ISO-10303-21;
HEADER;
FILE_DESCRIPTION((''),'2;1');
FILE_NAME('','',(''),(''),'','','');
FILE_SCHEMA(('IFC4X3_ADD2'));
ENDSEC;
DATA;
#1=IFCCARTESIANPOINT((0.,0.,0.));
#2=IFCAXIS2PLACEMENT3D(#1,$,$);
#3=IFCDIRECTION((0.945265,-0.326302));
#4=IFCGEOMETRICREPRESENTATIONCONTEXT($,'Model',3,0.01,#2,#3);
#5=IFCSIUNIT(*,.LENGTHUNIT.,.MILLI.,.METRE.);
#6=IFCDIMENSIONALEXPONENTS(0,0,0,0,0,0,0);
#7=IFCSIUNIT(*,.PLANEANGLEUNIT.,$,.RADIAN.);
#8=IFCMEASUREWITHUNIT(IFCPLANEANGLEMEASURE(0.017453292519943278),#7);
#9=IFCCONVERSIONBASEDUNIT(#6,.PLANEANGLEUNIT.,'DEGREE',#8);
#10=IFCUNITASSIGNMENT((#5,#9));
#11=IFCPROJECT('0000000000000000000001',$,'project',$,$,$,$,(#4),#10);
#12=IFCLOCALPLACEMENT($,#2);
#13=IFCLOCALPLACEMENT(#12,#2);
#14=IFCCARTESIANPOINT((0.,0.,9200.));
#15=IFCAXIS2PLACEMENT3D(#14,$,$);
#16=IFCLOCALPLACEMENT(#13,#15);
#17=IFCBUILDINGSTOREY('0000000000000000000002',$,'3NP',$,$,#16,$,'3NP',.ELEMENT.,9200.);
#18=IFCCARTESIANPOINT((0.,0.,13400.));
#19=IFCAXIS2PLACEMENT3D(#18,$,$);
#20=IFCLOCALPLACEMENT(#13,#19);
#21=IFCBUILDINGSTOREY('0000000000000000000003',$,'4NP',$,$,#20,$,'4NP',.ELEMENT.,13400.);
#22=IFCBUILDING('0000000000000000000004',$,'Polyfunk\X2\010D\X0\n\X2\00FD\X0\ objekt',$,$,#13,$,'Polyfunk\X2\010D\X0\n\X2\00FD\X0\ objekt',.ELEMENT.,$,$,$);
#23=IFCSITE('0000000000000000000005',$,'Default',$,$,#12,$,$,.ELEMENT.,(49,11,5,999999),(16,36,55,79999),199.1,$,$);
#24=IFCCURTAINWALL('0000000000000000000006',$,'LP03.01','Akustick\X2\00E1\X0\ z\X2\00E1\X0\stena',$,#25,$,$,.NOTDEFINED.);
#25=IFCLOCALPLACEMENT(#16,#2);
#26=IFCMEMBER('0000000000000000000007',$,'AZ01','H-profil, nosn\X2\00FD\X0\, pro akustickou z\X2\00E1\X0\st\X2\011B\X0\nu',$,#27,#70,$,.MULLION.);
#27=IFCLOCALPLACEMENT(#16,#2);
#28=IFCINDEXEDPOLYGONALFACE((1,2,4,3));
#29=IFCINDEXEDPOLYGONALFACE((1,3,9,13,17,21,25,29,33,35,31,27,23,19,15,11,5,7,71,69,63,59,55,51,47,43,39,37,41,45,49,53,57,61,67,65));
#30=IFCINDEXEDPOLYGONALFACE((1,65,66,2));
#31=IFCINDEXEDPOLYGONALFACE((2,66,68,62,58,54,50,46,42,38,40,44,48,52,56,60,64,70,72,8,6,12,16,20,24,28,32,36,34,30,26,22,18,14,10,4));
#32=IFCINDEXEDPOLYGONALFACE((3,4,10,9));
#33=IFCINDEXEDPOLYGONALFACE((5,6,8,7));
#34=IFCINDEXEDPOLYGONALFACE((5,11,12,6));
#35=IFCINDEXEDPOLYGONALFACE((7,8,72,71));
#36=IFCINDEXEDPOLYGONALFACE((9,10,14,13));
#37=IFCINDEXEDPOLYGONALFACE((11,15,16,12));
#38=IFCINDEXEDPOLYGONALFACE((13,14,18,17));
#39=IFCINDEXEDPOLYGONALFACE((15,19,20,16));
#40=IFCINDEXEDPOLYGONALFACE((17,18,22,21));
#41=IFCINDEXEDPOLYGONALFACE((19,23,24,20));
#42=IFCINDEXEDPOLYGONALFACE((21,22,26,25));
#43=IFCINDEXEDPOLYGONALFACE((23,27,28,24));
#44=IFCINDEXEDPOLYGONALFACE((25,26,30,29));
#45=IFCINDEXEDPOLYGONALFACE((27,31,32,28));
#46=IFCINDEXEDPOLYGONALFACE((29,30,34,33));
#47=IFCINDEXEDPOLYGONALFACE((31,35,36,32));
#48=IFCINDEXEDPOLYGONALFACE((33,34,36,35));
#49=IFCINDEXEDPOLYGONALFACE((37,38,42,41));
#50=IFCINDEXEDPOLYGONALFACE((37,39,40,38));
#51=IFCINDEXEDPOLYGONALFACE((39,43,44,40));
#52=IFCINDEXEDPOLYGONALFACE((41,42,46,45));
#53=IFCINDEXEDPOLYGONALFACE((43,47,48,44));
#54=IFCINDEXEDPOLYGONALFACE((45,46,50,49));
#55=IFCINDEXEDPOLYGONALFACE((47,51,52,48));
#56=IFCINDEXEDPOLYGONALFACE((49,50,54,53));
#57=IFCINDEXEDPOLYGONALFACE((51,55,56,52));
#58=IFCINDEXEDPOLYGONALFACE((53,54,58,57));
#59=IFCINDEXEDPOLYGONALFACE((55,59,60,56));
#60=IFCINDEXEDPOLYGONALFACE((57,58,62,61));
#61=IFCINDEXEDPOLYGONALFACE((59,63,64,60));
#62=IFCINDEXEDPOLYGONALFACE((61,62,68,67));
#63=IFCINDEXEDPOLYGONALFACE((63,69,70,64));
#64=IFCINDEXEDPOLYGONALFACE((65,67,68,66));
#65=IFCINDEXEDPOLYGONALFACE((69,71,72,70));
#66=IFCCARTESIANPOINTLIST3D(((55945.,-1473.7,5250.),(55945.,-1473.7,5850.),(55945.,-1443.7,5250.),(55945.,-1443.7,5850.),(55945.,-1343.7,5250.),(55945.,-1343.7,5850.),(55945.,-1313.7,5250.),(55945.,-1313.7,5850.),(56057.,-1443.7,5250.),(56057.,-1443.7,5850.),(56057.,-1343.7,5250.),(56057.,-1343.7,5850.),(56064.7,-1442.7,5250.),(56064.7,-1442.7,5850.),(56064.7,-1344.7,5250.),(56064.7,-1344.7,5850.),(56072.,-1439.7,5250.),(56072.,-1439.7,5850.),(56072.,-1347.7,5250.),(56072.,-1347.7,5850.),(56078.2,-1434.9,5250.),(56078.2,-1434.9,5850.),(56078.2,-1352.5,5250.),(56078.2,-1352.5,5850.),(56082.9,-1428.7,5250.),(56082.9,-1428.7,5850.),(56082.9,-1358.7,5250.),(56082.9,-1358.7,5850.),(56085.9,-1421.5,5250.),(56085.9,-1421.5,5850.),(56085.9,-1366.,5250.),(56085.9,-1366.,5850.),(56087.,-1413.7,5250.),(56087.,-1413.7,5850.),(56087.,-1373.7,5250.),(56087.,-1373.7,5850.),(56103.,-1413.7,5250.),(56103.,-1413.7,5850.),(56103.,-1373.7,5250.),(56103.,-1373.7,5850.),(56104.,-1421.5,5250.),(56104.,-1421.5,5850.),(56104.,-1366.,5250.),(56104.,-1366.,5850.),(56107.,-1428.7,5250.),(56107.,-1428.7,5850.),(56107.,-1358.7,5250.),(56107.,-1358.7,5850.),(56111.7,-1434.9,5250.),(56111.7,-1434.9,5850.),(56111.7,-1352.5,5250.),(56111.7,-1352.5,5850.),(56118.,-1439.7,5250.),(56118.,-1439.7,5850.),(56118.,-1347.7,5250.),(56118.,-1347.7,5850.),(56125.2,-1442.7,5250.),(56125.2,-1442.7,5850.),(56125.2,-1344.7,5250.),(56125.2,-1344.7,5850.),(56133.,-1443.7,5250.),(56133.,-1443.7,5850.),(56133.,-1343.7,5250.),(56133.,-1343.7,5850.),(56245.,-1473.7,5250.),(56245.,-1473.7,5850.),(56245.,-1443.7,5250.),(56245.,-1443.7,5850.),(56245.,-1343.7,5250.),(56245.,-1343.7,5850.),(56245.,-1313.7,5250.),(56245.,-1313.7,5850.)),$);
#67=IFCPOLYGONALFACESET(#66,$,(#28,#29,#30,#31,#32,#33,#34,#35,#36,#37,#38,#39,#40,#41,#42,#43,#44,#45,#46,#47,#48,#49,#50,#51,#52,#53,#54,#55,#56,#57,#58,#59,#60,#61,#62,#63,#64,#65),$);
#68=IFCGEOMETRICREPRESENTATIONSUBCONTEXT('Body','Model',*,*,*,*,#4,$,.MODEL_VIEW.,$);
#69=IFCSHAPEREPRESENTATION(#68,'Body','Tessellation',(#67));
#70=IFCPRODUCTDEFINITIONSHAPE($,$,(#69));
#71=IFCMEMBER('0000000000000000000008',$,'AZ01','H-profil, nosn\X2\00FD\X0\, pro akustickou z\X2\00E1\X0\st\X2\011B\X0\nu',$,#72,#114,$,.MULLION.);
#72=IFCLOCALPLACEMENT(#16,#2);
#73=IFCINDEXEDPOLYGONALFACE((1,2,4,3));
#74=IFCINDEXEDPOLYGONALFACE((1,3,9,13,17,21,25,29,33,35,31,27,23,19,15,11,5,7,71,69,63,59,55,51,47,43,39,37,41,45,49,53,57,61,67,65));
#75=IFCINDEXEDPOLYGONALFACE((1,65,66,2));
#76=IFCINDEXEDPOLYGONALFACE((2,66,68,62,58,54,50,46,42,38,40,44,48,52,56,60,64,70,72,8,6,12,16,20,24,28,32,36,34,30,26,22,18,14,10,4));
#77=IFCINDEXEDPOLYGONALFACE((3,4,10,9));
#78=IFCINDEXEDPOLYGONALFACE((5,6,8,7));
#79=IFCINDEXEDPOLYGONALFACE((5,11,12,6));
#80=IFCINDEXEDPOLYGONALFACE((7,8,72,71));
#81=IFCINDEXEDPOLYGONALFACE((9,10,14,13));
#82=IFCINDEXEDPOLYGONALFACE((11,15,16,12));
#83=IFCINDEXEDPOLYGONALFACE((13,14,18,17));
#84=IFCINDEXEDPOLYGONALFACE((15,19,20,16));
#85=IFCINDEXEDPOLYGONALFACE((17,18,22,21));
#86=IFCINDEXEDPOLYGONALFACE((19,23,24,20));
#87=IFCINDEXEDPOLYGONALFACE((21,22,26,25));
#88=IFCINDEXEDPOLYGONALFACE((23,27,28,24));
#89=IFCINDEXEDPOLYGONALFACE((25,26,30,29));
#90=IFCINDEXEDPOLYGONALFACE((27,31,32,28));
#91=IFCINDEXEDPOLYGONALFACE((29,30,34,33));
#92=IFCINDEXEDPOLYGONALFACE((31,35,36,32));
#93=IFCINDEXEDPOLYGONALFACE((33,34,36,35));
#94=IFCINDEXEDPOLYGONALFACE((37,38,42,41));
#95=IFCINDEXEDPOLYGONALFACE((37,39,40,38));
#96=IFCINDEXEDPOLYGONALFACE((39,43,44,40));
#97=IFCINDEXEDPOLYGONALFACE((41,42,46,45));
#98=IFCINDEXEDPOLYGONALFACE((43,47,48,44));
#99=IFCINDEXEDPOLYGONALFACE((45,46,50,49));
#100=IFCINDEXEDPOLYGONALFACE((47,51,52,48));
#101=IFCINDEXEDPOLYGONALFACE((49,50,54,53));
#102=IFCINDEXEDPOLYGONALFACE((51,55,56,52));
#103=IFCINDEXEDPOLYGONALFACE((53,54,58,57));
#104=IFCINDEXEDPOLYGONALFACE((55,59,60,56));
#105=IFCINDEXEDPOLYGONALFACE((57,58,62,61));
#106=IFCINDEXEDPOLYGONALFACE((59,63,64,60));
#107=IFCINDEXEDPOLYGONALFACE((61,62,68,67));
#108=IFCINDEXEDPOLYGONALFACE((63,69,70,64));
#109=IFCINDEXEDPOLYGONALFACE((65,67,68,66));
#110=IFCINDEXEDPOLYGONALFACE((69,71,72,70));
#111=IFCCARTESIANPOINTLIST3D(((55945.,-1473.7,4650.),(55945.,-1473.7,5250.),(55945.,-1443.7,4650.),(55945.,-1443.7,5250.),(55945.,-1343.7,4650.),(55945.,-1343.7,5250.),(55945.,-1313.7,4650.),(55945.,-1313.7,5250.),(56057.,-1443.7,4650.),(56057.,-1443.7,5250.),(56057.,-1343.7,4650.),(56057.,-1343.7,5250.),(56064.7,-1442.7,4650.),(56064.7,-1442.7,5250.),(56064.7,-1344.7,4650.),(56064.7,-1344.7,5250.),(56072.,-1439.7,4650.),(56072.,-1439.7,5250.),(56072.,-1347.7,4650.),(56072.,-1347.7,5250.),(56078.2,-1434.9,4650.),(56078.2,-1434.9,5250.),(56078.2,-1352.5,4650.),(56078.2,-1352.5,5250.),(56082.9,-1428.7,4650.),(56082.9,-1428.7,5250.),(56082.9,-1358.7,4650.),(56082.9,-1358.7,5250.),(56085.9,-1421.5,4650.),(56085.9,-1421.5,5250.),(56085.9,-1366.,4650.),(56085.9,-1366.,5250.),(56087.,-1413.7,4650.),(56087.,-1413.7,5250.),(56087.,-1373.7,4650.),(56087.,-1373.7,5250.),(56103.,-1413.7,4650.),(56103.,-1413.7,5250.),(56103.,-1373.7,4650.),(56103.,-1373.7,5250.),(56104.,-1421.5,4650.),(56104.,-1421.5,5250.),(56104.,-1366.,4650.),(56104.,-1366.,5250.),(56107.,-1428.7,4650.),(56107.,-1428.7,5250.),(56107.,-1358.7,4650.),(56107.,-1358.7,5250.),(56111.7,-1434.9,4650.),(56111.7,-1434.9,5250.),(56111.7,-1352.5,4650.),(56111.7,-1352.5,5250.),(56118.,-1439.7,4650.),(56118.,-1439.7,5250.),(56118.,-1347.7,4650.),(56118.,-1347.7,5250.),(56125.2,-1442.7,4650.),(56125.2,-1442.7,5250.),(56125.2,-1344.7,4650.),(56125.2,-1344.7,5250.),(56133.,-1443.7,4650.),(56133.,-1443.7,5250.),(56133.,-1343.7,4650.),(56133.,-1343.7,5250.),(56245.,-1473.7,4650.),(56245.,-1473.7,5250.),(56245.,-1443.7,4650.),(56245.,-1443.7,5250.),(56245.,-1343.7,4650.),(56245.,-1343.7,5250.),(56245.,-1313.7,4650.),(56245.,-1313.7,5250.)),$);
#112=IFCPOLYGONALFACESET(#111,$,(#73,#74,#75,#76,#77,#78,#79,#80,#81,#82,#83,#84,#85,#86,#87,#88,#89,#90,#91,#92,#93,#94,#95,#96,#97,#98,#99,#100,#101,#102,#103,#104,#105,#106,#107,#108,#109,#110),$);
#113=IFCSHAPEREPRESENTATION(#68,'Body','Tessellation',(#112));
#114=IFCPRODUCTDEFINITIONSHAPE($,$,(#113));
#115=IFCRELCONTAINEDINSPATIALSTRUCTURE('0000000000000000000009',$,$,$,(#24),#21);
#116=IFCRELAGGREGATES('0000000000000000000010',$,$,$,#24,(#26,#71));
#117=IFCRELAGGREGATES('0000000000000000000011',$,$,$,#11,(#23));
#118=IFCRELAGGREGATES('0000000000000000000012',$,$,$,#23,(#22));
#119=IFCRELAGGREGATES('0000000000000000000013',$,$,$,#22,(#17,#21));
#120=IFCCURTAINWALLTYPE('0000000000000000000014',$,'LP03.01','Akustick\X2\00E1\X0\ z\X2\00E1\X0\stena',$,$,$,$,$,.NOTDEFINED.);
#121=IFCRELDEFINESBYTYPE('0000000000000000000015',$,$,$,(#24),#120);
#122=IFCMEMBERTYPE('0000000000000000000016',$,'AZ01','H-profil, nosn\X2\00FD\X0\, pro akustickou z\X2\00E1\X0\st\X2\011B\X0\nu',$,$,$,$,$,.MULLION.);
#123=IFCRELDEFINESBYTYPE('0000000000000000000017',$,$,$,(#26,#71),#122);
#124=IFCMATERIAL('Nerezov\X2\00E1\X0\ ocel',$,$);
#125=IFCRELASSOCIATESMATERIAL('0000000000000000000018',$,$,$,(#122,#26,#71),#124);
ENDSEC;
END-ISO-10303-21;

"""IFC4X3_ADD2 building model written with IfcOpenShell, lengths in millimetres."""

from ifc_helpers import new_model, entity, si_unit, converted_unit, direction, frame, frame_2d, origin, place, context, subcontext, project, spatial, polyline, circle_curve, parameter, trimmed, segment, composite_curve, outline, extrude, source, transform, mapped, material, material_profile, profile_set, profile_usage, type_object, element, aggregate, save


model = new_model("IFC4X3_ADD2")

# Units and contexts
model_context = context("Model", 3, precision=0.01, world=origin(), true_north=direction((0.945265, -0.326302)))
body_context = subcontext(model_context, "Body", "Model", "MODEL_VIEW")
ifc_project = project(units=[si_unit("LENGTHUNIT", "METRE", prefix="MILLI"), converted_unit("PLANEANGLEUNIT", "DEGREE", entity("IfcPlaneAngleMeasure", 0.017453292519943278), si_unit("PLANEANGLEUNIT", "RADIAN"), dimensions=[0, 0, 0, 0, 0, 0, 0])], contexts=[model_context])

# Site, building, storey
site_placement = place(None, origin())
site = spatial("IfcSite", under=ifc_project, at=site_placement, Name="Default", CompositionType="ELEMENT", RefLatitude=(49, 11, 5, 999999), RefLongitude=(16, 36, 55, 79999), RefElevation=199.1)
building_placement = place(site_placement, origin())
building = spatial("IfcBuilding", under=site, at=building_placement, Name="Polyfunkčný objekt", LongName="Polyfunkčný objekt", CompositionType="ELEMENT")
storey_1_placement = place(building_placement, frame((0.0, 0.0, 9200.0)))
storey_1 = spatial("IfcBuildingStorey", under=building, at=storey_1_placement, Name="3NP", LongName="3NP", CompositionType="ELEMENT", Elevation=9200.0)

# Shared definitions
storey_2_placement = place(building_placement, frame((0.0, 0.0, 13400.0)))
storey_2 = spatial("IfcBuildingStorey", under=building, at=storey_2_placement, Name="4NP", LongName="4NP", CompositionType="ELEMENT", Elevation=13400.0)

# Curtain wall, members
curtain_wall_type_1 = type_object("IfcCurtainWallType", Name="LP03.01", Description="Akustická zástena", PredefinedType="NOTDEFINED")
ifc_material_1 = material(Name="Nerezová ocel")
ifc_material_profile_1 = material_profile(ifc_material_1, outline(composite_curve([segment(polyline([(50.0, -150.0), (80.0, -150.0)]), True, "CONTINUOUS"), segment(polyline([(80.0, -150.0), (80.0, 150.0)]), True, "CONTINUOUS"), segment(polyline([(80.0, 150.0), (50.0, 150.0)]), True, "CONTINUOUS"), segment(polyline([(50.0, 150.0), (50.0, 38.0)]), True, "CONTINUOUS"), segment(trimmed(circle_curve(frame_2d((20.0, 38.0), x_axis=(0.0, 1.0)), 30.0), [parameter(180.0)], [parameter(270.0)], True, "PARAMETER"), False, "CONTINUOUS"), segment(polyline([(20.0, 8.0), (-20.0, 8.0)]), True, "CONTINUOUS"), segment(trimmed(circle_curve(frame_2d((-20.0, 38.0), x_axis=(0.0, 1.0)), 30.0), [parameter(90.0)], [parameter(180.0)], True, "PARAMETER"), False, "CONTINUOUS"), segment(polyline([(-50.0, 38.0), (-50.0, 150.0)]), True, "CONTINUOUS"), segment(polyline([(-50.0, 150.0), (-80.0, 150.0)]), True, "CONTINUOUS"), segment(polyline([(-80.0, 150.0), (-80.0, -150.0)]), True, "CONTINUOUS"), segment(polyline([(-80.0, -150.0), (-50.0, -150.0)]), True, "CONTINUOUS"), segment(polyline([(-50.0, -150.0), (-50.0, -38.0)]), True, "CONTINUOUS"), segment(trimmed(circle_curve(frame_2d((-20.0, -38.0), x_axis=(0.0, 1.0)), 30.0), [parameter(0.0)], [parameter(90.0)], True, "PARAMETER"), False, "CONTINUOUS"), segment(polyline([(-20.0, -8.0), (20.0, -8.0)]), True, "CONTINUOUS"), segment(trimmed(circle_curve(frame_2d((20.0, -38.0), x_axis=(0.0, 1.0)), 30.0), [parameter(270.0)], [parameter(0.0)], True, "PARAMETER"), False, "CONTINUOUS"), segment(polyline([(50.0, -38.0), (50.0, -150.0)]), True, "CONTINUOUS")], self_intersect=False)), Name="Profil zástena")
ifc_profile_set_1 = profile_set([ifc_material_profile_1], Name="Profil zástena")
ifc_profile_usage_1 = profile_usage(ifc_profile_set_1)
member_type_1 = type_object("IfcMemberType", Name="AZ01", Description="H-profil, nosný, pro akustickou zástěnu", PredefinedType="MULLION", material=ifc_profile_set_1)
curtain_wall_1_placement = place(storey_2_placement, frame((0.0, 0.0, -13400.0)))
curtain_wall_1 = element("IfcCurtainWall", 1, at=curtain_wall_1_placement, inside=storey_2, type_object=curtain_wall_type_1, Name="LP03.01", Description="Akustická zástena", PredefinedType="NOTDEFINED")
shared_shape_1 = source(origin(), body_context, "Body", "SweptSolid", [
    extrude(outline(composite_curve([segment(polyline([(50.0, -150.0), (80.0, -150.0)]), True, "CONTINUOUS"), segment(polyline([(80.0, -150.0), (80.0, 150.0)]), True, "CONTINUOUS"), segment(polyline([(80.0, 150.0), (50.0, 150.0)]), True, "CONTINUOUS"), segment(polyline([(50.0, 150.0), (50.0, 38.0)]), True, "CONTINUOUS"), segment(trimmed(circle_curve(frame_2d((20.0, 38.0), x_axis=(0.0, 1.0)), 30.0), [parameter(180.0)], [parameter(270.0)], True, "PARAMETER"), False, "CONTINUOUS"), segment(polyline([(20.0, 8.0), (-20.0, 8.0)]), True, "CONTINUOUS"), segment(trimmed(circle_curve(frame_2d((-20.0, 38.0), x_axis=(0.0, 1.0)), 30.0), [parameter(90.0)], [parameter(180.0)], True, "PARAMETER"), False, "CONTINUOUS"), segment(polyline([(-50.0, 38.0), (-50.0, 150.0)]), True, "CONTINUOUS"), segment(polyline([(-50.0, 150.0), (-80.0, 150.0)]), True, "CONTINUOUS"), segment(polyline([(-80.0, 150.0), (-80.0, -150.0)]), True, "CONTINUOUS"), segment(polyline([(-80.0, -150.0), (-50.0, -150.0)]), True, "CONTINUOUS"), segment(polyline([(-50.0, -150.0), (-50.0, -38.0)]), True, "CONTINUOUS"), segment(trimmed(circle_curve(frame_2d((-20.0, -38.0), x_axis=(0.0, 1.0)), 30.0), [parameter(0.0)], [parameter(90.0)], True, "PARAMETER"), False, "CONTINUOUS"), segment(polyline([(-20.0, -8.0), (20.0, -8.0)]), True, "CONTINUOUS"), segment(trimmed(circle_curve(frame_2d((20.0, -38.0), x_axis=(0.0, 1.0)), 30.0), [parameter(270.0)], [parameter(0.0)], True, "PARAMETER"), False, "CONTINUOUS"), segment(polyline([(50.0, -38.0), (50.0, -150.0)]), True, "CONTINUOUS")], self_intersect=False)), frame((-150.0, 0.0, -600.0), z_axis=(0.0, 0.0, 1.0), x_axis=(0.0, -1.0, 0.0)), (0.0, 0.0, 1.0), 600.0),
])
member_1_placement = place(curtain_wall_1_placement, frame((56245.0, -1393.7, 14450.0), z_axis=(0.0, 0.0, -1.0), x_axis=(1.0, 0.0, 0.0)))
member_1 = element("IfcMember", 2, at=member_1_placement, type_object=member_type_1, material=ifc_profile_usage_1, Name="AZ01", Description="H-profil, nosný, pro akustickou zástěnu", PredefinedType="MULLION", context=body_context, shape_type="MappedRepresentation", body=[
    mapped(shared_shape_1, transform((0.0, 0.0, 0.0), scale=1.0)),
])
member_2_placement = place(curtain_wall_1_placement, frame((56245.0, -1393.7, 13850.0), z_axis=(0.0, 0.0, -1.0), x_axis=(1.0, 0.0, 0.0)))
member_2 = element("IfcMember", 3, at=member_2_placement, type_object=member_type_1, material=ifc_profile_usage_1, Name="AZ01", Description="H-profil, nosný, pro akustickou zástěnu", PredefinedType="MULLION", context=body_context, shape_type="MappedRepresentation", body=[
    mapped(shared_shape_1, transform((0.0, 0.0, 0.0), scale=1.0)),
])
aggregate(curtain_wall_1, [member_1, member_2])

save(model, "model.ifc")
